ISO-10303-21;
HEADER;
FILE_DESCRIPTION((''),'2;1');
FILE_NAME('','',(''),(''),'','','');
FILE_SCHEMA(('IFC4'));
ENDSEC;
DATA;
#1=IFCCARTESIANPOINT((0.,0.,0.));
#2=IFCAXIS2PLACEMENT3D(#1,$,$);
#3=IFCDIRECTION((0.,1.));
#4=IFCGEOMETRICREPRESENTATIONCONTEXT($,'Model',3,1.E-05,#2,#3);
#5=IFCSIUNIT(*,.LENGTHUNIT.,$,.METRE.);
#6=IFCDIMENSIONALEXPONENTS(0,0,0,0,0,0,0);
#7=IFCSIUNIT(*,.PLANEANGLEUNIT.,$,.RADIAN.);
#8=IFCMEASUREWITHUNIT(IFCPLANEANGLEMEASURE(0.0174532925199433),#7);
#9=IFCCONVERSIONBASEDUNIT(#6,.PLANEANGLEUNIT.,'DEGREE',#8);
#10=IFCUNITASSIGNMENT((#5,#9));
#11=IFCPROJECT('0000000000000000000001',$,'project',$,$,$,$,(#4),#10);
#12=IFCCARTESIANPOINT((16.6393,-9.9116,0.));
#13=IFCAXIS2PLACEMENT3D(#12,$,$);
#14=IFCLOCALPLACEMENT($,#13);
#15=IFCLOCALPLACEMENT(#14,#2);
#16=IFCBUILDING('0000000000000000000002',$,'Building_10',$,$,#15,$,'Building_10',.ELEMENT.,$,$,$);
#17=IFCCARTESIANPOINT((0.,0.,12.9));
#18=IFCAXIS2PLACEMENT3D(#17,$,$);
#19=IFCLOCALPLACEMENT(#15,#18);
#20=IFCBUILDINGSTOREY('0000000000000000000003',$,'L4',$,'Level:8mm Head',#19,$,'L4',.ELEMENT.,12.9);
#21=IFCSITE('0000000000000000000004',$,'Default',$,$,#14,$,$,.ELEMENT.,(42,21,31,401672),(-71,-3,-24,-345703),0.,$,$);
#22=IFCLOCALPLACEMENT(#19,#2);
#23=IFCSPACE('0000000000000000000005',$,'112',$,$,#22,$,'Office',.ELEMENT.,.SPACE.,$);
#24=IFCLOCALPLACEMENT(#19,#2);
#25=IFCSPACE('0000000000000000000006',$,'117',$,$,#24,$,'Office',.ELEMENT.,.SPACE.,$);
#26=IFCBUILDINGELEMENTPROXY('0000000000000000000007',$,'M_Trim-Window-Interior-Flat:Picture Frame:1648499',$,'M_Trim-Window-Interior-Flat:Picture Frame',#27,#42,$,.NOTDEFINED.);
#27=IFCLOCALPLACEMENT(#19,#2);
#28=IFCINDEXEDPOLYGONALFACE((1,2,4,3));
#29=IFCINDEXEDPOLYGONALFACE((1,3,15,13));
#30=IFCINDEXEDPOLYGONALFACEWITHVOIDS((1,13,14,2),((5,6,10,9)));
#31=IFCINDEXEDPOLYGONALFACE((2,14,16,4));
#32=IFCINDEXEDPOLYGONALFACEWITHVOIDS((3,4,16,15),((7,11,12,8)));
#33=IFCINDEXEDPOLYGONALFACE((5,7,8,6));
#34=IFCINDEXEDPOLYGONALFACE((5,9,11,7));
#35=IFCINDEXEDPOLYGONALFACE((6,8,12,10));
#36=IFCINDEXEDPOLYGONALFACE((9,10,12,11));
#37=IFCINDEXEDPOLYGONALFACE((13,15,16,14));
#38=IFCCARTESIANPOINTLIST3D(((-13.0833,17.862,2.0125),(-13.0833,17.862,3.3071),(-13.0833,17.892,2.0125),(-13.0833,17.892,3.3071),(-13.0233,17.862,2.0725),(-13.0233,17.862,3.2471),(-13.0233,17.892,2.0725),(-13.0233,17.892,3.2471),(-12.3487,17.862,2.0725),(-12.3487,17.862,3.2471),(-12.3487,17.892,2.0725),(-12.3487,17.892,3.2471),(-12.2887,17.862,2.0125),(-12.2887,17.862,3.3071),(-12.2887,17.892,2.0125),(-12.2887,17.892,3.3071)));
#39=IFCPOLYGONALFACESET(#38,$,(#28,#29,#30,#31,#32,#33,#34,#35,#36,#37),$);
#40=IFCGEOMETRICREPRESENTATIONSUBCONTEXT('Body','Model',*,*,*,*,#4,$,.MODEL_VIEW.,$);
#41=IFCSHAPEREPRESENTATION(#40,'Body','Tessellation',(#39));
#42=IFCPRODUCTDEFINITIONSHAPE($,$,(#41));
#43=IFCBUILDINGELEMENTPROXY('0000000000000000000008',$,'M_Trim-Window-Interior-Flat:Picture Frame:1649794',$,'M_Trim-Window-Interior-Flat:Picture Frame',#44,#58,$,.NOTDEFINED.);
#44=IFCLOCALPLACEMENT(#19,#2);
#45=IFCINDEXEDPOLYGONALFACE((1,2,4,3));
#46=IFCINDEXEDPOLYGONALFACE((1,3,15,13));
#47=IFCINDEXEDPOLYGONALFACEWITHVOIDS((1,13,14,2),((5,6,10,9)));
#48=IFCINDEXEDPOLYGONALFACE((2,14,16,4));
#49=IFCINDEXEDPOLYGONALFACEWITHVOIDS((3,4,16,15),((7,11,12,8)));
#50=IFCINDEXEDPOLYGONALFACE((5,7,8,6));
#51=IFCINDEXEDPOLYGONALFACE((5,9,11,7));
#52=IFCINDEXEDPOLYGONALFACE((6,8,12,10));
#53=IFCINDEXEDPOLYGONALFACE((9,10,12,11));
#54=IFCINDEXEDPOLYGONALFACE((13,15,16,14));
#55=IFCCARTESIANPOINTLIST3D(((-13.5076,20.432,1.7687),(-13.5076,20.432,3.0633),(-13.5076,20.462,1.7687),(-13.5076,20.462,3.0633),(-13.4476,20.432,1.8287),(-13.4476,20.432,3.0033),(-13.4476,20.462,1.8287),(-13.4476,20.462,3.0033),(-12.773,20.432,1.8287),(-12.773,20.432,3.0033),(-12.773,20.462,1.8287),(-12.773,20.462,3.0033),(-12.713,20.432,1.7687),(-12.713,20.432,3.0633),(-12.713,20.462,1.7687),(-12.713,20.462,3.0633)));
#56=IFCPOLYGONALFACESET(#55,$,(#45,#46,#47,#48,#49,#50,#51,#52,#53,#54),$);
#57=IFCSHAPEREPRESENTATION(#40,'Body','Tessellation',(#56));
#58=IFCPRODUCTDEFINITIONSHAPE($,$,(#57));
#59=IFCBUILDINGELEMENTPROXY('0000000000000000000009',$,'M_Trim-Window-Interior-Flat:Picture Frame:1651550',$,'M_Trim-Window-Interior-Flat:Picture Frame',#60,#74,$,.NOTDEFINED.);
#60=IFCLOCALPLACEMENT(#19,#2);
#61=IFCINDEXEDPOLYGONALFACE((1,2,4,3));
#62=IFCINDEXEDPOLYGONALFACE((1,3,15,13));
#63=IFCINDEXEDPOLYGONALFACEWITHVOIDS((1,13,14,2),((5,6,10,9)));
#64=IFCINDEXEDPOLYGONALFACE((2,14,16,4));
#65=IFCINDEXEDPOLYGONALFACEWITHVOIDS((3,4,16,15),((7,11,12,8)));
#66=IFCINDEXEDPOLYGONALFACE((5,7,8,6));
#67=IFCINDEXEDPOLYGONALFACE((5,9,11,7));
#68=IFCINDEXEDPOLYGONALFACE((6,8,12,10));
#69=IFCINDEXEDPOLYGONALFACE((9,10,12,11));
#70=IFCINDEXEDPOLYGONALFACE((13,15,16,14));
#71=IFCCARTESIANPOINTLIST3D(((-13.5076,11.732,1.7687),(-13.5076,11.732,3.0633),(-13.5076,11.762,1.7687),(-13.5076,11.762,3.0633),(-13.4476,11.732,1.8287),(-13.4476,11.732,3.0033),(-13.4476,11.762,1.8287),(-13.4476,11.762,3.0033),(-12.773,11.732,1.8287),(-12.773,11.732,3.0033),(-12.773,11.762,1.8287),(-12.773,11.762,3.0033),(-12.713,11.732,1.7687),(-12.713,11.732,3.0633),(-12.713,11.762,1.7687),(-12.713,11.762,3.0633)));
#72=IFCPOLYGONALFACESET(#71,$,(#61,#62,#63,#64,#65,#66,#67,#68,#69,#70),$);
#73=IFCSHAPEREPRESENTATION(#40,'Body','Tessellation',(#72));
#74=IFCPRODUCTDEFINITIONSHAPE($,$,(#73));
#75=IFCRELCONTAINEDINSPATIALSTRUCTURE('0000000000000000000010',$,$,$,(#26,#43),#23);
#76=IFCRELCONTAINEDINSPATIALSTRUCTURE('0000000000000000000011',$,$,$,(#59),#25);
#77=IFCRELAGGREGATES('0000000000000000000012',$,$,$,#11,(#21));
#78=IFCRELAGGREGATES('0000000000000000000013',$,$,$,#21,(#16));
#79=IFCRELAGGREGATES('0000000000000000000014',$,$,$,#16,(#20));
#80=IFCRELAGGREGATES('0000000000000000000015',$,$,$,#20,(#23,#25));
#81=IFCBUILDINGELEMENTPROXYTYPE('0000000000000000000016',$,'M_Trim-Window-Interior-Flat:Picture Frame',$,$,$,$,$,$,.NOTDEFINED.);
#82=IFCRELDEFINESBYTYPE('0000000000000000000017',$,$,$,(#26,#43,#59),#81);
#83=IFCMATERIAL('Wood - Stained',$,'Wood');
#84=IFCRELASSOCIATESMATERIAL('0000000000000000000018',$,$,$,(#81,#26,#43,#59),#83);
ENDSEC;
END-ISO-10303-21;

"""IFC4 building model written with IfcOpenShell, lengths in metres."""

from ifc_helpers import new_model, entity, si_unit, converted_unit, direction, frame, origin, place, context, subcontext, project, spatial, indexed_curve, outline, extrude, source, transform, mapped, material, type_object, type_shapes, element, save


model = new_model("IFC4")

# Units and contexts
model_context = context("Model", 3, precision=1e-05, world=origin(), true_north=direction((0.0, 1.0)))
body_context = subcontext(model_context, "Body", "Model", "MODEL_VIEW")
ifc_project = project(units=[si_unit("LENGTHUNIT", "METRE"), converted_unit("PLANEANGLEUNIT", "DEGREE", entity("IfcPlaneAngleMeasure", 0.0174532925199433), si_unit("PLANEANGLEUNIT", "RADIAN"), dimensions=[0, 0, 0, 0, 0, 0, 0])], contexts=[model_context])

# Site, building, storey
site_placement = place(None, frame((16.6393, -9.9116, 0.0)))
site = spatial("IfcSite", under=ifc_project, at=site_placement, Name="Default", CompositionType="ELEMENT", RefLatitude=(42, 21, 31, 401672), RefLongitude=(-71, -3, -24, -345703), RefElevation=0.0)
building_placement = place(site_placement, origin())
building = spatial("IfcBuilding", under=site, at=building_placement, Name="Building_10", LongName="Building_10", CompositionType="ELEMENT")
storey_placement = place(building_placement, frame((0.0, 0.0, 12.9)))
storey = spatial("IfcBuildingStorey", under=building, at=storey_placement, Name="L4", ObjectType="Level:8mm Head", LongName="L4", CompositionType="ELEMENT", Elevation=12.9)

# Shared definitions
ifc_material_1 = material(Name="Wood - Stained", Category="Wood")

# Shared definitions
space_1_placement = place(storey_placement, origin())
space_1 = spatial("IfcSpace", under=storey, at=space_1_placement, Name="112", LongName="Office", CompositionType="ELEMENT", PredefinedType="SPACE")

# Building element proxies
building_element_proxy_type_1 = type_object("IfcBuildingElementProxyType", Name="M_Trim-Window-Interior-Flat:Picture Frame", PredefinedType="NOTDEFINED", material=ifc_material_1)
shared_shape_1 = source(origin(), body_context, "Body", "SweptSolid", [
    extrude(outline(indexed_curve([(-0.3973, -0.6473), (0.3973, -0.6473), (0.3973, 0.6473), (-0.3973, 0.6473), (-0.3973, -0.6473)], self_intersect=False), holes=[indexed_curve([(-0.3373, -0.5873), (-0.3373, 0.5873), (0.3373, 0.5873), (0.3373, -0.5873), (-0.3373, -0.5873)], self_intersect=False)]), frame((0.0, -0.6, 0.0), z_axis=(0.0, 0.0, 1.0), x_axis=(-1.0, 0.0, 0.0)), (0.0, 0.0, 1.0), 0.03),
])
type_shapes(building_element_proxy_type_1, [shared_shape_1])
for number, where, z_axis, x_axis, name in (
    (1, (-12.686, 17.862, 3.2598), (0.0, 1.0, 0.0), (-1.0, 0.0, 0.0), "M_Trim-Window-Interior-Flat:Picture Frame:1648499"),
    (2, (-13.1103, 20.462, 3.016), (0.0, -1.0, 0.0), (1.0, 0.0, 0.0), "M_Trim-Window-Interior-Flat:Picture Frame:1649794"),
):
    element("IfcBuildingElementProxy", number, at=place(space_1_placement, frame(where, z_axis=z_axis, x_axis=x_axis)), inside=space_1, type_object=building_element_proxy_type_1, material=ifc_material_1, Name=name, ObjectType="M_Trim-Window-Interior-Flat:Picture Frame", PredefinedType="NOTDEFINED", context=body_context, shape_type="MappedRepresentation", body=[
        mapped(shared_shape_1, transform((0.0, 0.0, 0.0), scale=1.0)),
    ])

# Shared definitions
space_2_placement = place(storey_placement, origin())
space_2 = spatial("IfcSpace", under=storey, at=space_2_placement, Name="117", LongName="Office", CompositionType="ELEMENT", PredefinedType="SPACE")

# Building element proxy
proxy_1_placement = place(space_2_placement, frame((-13.1103, 11.762, 3.016), z_axis=(0.0, -1.0, 0.0), x_axis=(1.0, 0.0, 0.0)))
element("IfcBuildingElementProxy", 3, at=proxy_1_placement, inside=space_2, type_object=building_element_proxy_type_1, material=ifc_material_1, Name="M_Trim-Window-Interior-Flat:Picture Frame:1651550", ObjectType="M_Trim-Window-Interior-Flat:Picture Frame", PredefinedType="NOTDEFINED", context=body_context, shape_type="MappedRepresentation", body=[
    mapped(shared_shape_1, transform((0.0, 0.0, 0.0), scale=1.0)),
])

save(model, "model.ifc")
